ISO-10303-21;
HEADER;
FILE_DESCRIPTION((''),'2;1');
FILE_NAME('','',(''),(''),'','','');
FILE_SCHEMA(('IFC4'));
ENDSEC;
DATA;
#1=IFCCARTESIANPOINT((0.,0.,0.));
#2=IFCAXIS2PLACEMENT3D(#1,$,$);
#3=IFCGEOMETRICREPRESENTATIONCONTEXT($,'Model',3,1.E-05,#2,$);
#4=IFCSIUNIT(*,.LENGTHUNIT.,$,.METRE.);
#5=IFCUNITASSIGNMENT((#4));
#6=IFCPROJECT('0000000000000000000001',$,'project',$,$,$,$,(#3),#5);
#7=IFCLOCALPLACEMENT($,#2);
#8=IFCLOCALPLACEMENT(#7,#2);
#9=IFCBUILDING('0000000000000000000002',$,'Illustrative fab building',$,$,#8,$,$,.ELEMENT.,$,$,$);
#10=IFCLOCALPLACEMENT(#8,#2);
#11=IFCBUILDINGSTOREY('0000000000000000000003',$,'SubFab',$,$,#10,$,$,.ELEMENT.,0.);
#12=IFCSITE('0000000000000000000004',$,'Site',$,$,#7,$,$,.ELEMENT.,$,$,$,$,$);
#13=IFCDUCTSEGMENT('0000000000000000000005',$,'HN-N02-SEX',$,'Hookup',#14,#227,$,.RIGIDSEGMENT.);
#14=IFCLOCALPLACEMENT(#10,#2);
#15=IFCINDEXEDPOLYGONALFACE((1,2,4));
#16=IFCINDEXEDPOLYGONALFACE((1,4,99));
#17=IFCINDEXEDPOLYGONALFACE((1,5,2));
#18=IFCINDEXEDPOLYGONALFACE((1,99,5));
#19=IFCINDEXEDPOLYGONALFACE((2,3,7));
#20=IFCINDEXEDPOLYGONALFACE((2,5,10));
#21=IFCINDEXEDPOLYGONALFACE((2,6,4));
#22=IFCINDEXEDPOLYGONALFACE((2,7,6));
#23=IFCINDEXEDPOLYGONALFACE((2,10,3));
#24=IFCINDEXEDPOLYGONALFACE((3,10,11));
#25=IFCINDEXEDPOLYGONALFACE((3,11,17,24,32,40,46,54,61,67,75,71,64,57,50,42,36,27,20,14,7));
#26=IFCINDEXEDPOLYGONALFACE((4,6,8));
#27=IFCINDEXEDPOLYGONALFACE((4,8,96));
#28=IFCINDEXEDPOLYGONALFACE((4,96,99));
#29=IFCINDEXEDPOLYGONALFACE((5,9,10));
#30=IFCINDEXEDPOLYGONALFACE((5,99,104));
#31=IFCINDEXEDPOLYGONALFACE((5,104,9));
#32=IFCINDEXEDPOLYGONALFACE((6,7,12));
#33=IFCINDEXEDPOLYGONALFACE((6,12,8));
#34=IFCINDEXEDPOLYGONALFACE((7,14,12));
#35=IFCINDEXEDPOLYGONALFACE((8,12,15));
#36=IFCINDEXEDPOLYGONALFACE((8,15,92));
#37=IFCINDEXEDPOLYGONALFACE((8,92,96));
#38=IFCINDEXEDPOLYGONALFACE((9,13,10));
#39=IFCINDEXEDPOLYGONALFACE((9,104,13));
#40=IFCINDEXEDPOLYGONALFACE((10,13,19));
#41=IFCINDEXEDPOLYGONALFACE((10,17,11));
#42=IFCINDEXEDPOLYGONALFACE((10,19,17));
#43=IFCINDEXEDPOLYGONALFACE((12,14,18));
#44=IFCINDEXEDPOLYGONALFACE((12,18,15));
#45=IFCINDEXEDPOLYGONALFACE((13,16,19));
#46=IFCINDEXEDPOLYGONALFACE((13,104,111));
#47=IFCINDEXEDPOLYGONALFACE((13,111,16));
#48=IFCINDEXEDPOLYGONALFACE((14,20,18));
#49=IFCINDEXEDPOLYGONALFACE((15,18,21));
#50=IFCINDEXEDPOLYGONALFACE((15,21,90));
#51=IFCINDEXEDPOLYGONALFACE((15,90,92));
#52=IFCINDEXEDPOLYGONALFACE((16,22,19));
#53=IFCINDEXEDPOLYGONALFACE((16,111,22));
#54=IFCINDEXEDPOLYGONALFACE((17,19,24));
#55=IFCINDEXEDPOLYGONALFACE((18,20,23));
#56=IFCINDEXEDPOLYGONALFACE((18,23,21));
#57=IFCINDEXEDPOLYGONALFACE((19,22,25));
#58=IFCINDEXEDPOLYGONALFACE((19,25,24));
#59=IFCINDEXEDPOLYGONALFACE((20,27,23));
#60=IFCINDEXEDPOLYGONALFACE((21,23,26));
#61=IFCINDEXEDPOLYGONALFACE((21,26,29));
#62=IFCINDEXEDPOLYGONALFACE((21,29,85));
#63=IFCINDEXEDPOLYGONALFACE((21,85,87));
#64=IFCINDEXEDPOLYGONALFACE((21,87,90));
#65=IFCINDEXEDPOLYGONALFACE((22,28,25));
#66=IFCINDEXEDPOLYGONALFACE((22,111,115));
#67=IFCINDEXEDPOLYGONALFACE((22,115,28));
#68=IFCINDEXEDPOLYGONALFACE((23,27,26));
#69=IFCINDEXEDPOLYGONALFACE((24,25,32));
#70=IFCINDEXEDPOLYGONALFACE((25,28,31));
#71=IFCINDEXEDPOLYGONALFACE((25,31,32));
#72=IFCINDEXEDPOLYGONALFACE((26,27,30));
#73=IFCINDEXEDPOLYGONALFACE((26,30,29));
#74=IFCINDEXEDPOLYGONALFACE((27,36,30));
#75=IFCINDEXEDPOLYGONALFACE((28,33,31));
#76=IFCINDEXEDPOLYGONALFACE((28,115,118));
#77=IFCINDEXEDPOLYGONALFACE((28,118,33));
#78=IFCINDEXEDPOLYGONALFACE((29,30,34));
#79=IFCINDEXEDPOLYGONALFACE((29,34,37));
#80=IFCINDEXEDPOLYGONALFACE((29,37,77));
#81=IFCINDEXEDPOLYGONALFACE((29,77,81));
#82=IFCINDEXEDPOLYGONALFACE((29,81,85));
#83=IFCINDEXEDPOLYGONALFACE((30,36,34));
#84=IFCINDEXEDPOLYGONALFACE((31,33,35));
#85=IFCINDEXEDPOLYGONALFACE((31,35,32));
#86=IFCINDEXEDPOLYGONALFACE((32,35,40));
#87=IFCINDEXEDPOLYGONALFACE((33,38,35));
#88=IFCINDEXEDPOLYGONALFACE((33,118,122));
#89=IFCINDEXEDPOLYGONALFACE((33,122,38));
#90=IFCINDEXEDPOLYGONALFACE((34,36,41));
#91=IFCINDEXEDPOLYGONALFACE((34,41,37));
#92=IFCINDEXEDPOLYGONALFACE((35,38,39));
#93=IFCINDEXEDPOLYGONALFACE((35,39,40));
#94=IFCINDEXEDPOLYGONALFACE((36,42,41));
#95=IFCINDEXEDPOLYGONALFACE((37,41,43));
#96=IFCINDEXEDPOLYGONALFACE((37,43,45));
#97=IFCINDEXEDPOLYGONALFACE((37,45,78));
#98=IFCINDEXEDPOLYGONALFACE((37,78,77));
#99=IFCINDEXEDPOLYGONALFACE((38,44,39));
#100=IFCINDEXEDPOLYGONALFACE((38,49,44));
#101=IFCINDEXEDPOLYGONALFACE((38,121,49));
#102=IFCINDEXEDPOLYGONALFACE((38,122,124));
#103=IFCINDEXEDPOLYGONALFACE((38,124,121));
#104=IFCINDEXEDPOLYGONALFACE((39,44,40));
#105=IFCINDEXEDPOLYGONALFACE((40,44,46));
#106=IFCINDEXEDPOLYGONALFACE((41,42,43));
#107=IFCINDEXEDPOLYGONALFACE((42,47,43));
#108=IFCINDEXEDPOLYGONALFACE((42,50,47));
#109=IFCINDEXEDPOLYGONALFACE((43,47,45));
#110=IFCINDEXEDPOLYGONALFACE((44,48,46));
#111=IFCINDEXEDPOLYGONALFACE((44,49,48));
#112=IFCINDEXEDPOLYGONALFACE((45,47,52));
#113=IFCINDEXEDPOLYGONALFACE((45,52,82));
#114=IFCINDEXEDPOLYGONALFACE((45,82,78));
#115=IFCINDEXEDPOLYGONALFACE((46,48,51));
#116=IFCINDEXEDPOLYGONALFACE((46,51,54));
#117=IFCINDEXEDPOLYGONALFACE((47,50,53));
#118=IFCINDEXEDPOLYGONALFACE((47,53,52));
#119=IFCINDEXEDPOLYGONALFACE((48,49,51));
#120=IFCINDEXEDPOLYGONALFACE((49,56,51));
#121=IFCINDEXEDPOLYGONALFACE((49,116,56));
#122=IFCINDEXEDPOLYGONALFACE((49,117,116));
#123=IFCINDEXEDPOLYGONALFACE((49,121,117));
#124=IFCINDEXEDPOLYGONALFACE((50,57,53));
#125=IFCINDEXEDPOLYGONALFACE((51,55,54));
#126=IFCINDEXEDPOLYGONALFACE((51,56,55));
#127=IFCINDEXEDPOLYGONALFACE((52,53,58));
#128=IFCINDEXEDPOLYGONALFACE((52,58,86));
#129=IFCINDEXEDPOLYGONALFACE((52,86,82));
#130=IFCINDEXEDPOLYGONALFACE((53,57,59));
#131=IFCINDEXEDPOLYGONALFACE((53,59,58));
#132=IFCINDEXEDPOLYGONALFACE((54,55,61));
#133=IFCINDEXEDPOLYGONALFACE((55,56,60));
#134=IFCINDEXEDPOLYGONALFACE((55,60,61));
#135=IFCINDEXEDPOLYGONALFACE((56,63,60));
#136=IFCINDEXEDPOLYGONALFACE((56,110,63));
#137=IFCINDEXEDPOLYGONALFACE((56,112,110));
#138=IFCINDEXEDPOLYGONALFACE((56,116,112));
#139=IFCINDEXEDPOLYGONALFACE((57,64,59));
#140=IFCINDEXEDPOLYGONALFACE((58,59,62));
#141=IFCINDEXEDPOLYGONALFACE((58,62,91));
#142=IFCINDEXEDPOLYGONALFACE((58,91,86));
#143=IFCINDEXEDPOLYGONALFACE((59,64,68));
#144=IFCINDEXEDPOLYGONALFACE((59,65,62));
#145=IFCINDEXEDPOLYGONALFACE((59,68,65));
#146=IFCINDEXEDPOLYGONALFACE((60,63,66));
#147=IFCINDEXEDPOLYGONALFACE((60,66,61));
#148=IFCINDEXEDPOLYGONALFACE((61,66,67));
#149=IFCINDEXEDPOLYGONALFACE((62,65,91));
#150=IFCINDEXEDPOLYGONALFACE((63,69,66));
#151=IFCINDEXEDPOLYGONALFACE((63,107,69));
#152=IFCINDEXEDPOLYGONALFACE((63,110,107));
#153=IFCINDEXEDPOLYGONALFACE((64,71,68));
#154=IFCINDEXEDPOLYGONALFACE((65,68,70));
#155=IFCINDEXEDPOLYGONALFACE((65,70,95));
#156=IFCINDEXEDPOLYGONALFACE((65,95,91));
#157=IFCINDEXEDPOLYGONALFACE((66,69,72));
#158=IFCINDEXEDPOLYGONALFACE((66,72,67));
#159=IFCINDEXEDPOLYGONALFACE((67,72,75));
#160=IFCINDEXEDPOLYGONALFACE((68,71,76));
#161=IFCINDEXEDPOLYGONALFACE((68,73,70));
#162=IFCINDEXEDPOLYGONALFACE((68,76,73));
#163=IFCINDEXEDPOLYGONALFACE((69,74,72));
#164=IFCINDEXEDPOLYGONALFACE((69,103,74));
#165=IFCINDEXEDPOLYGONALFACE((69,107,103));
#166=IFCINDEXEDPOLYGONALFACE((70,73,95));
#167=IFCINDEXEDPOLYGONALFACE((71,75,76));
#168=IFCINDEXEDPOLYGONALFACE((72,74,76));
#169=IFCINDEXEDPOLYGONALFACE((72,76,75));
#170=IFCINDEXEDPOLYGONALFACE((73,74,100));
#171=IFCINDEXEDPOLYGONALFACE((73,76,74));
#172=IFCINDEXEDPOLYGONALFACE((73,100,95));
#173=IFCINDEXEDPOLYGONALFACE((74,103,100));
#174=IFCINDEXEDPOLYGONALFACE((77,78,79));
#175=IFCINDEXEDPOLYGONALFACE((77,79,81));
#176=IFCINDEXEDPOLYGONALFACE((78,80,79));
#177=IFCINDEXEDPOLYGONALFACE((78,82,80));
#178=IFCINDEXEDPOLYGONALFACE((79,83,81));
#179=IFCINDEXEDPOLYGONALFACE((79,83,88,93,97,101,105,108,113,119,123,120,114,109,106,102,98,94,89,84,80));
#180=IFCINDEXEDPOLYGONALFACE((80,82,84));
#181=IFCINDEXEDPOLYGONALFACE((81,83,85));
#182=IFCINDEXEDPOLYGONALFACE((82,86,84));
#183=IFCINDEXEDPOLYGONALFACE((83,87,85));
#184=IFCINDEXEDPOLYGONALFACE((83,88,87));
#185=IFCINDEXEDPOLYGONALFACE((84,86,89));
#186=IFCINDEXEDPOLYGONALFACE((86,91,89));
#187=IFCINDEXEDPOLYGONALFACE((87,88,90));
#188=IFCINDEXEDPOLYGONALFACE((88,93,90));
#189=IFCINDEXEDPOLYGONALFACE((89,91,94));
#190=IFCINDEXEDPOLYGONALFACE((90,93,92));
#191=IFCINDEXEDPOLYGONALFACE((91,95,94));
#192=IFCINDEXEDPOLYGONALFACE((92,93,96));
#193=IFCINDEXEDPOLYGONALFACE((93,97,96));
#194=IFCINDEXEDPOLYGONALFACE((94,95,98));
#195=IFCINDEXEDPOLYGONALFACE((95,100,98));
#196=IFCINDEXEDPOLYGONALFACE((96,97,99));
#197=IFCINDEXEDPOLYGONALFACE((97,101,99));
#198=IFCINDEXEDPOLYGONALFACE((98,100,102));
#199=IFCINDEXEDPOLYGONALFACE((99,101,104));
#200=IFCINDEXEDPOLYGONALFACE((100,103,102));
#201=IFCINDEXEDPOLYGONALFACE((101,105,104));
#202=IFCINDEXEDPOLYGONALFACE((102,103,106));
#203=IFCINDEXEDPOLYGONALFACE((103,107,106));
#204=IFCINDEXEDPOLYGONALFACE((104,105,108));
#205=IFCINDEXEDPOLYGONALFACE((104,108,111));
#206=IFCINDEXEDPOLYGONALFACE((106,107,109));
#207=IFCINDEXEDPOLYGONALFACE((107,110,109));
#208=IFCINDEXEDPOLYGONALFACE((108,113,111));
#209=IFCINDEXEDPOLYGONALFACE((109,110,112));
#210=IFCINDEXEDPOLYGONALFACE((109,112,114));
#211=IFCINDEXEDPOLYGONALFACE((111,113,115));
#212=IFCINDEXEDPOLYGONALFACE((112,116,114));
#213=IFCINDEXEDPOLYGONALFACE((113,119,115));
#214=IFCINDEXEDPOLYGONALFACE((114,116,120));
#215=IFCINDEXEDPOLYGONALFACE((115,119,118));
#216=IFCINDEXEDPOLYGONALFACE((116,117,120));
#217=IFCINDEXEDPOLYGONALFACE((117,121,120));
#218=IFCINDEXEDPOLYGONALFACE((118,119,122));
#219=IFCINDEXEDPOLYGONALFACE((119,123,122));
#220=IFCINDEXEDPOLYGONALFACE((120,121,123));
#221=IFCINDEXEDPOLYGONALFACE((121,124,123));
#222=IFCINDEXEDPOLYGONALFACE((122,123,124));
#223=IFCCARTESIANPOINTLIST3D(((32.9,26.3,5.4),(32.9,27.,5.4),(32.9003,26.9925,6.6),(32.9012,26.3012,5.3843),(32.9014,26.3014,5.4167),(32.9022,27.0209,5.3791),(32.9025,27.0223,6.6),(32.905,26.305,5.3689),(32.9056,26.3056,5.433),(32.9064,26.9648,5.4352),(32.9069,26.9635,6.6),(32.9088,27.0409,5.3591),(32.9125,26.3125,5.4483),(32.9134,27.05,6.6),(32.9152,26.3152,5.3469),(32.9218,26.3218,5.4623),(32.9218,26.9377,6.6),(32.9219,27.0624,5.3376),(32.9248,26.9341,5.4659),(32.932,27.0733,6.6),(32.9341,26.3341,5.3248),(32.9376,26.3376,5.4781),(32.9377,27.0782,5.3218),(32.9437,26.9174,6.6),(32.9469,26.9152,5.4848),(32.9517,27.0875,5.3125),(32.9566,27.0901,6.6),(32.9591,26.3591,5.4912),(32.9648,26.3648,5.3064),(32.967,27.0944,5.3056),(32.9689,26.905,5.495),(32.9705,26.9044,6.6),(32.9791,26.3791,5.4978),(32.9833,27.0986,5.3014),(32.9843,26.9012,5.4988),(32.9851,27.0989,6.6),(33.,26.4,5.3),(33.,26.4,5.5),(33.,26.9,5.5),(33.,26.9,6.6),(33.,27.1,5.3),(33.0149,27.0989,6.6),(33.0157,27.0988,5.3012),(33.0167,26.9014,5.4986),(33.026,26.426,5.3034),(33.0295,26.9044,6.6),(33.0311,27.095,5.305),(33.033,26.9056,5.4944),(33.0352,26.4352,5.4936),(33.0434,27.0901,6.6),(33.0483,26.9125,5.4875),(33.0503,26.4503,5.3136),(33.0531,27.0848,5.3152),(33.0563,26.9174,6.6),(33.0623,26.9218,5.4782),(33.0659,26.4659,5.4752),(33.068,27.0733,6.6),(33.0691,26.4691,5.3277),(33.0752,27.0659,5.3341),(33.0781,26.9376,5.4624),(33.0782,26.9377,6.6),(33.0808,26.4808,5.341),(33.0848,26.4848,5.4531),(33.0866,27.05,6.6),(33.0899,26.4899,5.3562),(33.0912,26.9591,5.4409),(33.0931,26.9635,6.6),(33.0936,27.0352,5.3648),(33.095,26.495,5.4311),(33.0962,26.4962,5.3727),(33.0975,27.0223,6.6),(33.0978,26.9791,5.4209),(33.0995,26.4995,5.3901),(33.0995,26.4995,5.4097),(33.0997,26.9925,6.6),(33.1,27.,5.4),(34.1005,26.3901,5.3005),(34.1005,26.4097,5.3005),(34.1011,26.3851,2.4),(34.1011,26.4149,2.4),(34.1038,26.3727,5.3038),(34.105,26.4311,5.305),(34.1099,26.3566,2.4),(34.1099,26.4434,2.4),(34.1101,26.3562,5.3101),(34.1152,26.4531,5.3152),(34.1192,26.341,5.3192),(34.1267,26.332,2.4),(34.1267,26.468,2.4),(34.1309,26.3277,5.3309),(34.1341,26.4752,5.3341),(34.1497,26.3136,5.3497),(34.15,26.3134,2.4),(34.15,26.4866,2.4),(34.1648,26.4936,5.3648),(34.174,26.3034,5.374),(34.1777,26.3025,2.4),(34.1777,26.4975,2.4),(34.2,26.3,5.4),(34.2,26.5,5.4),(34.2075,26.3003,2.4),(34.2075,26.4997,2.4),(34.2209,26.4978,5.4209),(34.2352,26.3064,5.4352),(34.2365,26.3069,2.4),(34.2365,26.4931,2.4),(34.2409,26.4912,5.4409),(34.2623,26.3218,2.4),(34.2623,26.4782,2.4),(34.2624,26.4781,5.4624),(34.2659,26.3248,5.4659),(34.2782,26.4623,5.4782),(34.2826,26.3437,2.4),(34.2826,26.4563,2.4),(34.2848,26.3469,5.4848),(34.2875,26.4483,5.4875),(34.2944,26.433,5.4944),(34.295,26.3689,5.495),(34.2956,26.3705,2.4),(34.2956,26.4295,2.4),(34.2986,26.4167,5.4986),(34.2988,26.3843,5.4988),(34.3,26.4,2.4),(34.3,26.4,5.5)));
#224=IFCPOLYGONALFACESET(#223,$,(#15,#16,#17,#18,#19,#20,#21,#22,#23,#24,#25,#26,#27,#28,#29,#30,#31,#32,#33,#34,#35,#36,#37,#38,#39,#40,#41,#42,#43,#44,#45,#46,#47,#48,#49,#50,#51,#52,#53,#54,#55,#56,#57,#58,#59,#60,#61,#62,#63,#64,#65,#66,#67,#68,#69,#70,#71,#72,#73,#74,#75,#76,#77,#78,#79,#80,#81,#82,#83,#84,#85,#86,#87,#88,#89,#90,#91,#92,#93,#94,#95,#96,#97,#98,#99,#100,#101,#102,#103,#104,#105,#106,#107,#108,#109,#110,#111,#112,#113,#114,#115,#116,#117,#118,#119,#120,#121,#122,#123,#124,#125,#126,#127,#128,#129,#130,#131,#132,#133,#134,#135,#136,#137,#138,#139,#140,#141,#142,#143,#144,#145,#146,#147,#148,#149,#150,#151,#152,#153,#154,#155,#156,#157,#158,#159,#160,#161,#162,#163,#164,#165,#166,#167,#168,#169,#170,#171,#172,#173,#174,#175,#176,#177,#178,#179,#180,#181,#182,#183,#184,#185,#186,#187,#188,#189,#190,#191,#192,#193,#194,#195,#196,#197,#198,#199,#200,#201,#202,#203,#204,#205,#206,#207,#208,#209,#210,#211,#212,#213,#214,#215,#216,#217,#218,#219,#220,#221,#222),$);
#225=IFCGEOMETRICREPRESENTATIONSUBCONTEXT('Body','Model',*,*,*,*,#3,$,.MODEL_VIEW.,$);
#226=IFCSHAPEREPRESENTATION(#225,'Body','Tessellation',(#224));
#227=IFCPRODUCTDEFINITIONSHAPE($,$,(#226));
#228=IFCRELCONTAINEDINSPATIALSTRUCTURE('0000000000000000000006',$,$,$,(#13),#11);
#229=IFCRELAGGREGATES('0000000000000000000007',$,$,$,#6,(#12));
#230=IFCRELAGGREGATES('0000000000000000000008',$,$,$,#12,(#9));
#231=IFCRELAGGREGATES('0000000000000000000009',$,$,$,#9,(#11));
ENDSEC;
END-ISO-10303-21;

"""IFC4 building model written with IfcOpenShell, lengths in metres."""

from ifc_helpers import new_model, entity, si_unit, origin, place, context, subcontext, project, spatial, element, save


model = new_model("IFC4")

# Units and contexts
model_context = context("Model", 3, precision=1e-05, world=origin())
body_context = subcontext(model_context, "Body", "Model", "MODEL_VIEW")
ifc_project = project(units=[si_unit("LENGTHUNIT", "METRE")], contexts=[model_context])

# Site, building, storey
site_placement = place(None, origin())
site = spatial("IfcSite", under=ifc_project, at=site_placement, Name="Site", CompositionType="ELEMENT")
building_placement = place(site_placement, origin())
building = spatial("IfcBuilding", under=site, at=building_placement, Name="Illustrative fab building", CompositionType="ELEMENT")
storey_placement = place(building_placement, origin())
storey = spatial("IfcBuildingStorey", under=building, at=storey_placement, Name="SubFab", CompositionType="ELEMENT", Elevation=0.0)

# Duct segment
duct_segment_1_placement = place(storey_placement, origin())
element("IfcDuctSegment", 1, at=duct_segment_1_placement, inside=storey, Name="HN-N02-SEX", ObjectType="Hookup", PredefinedType="RIGIDSEGMENT", context=body_context, shape_type="AdvancedSweptSolid", body=[
    entity("IfcSweptDiskSolid", entity("IfcPolyline", [entity("IfcCartesianPoint", [34.2, 26.4, 2.4]), entity("IfcCartesianPoint", [34.2, 26.4, 5.4]), entity("IfcCartesianPoint", [33.0, 26.4, 5.4]), entity("IfcCartesianPoint", [33.0, 27.0, 5.4]), entity("IfcCartesianPoint", [33.0, 27.0, 6.6])]), 0.1),
])

save(model, "model.ifc")
